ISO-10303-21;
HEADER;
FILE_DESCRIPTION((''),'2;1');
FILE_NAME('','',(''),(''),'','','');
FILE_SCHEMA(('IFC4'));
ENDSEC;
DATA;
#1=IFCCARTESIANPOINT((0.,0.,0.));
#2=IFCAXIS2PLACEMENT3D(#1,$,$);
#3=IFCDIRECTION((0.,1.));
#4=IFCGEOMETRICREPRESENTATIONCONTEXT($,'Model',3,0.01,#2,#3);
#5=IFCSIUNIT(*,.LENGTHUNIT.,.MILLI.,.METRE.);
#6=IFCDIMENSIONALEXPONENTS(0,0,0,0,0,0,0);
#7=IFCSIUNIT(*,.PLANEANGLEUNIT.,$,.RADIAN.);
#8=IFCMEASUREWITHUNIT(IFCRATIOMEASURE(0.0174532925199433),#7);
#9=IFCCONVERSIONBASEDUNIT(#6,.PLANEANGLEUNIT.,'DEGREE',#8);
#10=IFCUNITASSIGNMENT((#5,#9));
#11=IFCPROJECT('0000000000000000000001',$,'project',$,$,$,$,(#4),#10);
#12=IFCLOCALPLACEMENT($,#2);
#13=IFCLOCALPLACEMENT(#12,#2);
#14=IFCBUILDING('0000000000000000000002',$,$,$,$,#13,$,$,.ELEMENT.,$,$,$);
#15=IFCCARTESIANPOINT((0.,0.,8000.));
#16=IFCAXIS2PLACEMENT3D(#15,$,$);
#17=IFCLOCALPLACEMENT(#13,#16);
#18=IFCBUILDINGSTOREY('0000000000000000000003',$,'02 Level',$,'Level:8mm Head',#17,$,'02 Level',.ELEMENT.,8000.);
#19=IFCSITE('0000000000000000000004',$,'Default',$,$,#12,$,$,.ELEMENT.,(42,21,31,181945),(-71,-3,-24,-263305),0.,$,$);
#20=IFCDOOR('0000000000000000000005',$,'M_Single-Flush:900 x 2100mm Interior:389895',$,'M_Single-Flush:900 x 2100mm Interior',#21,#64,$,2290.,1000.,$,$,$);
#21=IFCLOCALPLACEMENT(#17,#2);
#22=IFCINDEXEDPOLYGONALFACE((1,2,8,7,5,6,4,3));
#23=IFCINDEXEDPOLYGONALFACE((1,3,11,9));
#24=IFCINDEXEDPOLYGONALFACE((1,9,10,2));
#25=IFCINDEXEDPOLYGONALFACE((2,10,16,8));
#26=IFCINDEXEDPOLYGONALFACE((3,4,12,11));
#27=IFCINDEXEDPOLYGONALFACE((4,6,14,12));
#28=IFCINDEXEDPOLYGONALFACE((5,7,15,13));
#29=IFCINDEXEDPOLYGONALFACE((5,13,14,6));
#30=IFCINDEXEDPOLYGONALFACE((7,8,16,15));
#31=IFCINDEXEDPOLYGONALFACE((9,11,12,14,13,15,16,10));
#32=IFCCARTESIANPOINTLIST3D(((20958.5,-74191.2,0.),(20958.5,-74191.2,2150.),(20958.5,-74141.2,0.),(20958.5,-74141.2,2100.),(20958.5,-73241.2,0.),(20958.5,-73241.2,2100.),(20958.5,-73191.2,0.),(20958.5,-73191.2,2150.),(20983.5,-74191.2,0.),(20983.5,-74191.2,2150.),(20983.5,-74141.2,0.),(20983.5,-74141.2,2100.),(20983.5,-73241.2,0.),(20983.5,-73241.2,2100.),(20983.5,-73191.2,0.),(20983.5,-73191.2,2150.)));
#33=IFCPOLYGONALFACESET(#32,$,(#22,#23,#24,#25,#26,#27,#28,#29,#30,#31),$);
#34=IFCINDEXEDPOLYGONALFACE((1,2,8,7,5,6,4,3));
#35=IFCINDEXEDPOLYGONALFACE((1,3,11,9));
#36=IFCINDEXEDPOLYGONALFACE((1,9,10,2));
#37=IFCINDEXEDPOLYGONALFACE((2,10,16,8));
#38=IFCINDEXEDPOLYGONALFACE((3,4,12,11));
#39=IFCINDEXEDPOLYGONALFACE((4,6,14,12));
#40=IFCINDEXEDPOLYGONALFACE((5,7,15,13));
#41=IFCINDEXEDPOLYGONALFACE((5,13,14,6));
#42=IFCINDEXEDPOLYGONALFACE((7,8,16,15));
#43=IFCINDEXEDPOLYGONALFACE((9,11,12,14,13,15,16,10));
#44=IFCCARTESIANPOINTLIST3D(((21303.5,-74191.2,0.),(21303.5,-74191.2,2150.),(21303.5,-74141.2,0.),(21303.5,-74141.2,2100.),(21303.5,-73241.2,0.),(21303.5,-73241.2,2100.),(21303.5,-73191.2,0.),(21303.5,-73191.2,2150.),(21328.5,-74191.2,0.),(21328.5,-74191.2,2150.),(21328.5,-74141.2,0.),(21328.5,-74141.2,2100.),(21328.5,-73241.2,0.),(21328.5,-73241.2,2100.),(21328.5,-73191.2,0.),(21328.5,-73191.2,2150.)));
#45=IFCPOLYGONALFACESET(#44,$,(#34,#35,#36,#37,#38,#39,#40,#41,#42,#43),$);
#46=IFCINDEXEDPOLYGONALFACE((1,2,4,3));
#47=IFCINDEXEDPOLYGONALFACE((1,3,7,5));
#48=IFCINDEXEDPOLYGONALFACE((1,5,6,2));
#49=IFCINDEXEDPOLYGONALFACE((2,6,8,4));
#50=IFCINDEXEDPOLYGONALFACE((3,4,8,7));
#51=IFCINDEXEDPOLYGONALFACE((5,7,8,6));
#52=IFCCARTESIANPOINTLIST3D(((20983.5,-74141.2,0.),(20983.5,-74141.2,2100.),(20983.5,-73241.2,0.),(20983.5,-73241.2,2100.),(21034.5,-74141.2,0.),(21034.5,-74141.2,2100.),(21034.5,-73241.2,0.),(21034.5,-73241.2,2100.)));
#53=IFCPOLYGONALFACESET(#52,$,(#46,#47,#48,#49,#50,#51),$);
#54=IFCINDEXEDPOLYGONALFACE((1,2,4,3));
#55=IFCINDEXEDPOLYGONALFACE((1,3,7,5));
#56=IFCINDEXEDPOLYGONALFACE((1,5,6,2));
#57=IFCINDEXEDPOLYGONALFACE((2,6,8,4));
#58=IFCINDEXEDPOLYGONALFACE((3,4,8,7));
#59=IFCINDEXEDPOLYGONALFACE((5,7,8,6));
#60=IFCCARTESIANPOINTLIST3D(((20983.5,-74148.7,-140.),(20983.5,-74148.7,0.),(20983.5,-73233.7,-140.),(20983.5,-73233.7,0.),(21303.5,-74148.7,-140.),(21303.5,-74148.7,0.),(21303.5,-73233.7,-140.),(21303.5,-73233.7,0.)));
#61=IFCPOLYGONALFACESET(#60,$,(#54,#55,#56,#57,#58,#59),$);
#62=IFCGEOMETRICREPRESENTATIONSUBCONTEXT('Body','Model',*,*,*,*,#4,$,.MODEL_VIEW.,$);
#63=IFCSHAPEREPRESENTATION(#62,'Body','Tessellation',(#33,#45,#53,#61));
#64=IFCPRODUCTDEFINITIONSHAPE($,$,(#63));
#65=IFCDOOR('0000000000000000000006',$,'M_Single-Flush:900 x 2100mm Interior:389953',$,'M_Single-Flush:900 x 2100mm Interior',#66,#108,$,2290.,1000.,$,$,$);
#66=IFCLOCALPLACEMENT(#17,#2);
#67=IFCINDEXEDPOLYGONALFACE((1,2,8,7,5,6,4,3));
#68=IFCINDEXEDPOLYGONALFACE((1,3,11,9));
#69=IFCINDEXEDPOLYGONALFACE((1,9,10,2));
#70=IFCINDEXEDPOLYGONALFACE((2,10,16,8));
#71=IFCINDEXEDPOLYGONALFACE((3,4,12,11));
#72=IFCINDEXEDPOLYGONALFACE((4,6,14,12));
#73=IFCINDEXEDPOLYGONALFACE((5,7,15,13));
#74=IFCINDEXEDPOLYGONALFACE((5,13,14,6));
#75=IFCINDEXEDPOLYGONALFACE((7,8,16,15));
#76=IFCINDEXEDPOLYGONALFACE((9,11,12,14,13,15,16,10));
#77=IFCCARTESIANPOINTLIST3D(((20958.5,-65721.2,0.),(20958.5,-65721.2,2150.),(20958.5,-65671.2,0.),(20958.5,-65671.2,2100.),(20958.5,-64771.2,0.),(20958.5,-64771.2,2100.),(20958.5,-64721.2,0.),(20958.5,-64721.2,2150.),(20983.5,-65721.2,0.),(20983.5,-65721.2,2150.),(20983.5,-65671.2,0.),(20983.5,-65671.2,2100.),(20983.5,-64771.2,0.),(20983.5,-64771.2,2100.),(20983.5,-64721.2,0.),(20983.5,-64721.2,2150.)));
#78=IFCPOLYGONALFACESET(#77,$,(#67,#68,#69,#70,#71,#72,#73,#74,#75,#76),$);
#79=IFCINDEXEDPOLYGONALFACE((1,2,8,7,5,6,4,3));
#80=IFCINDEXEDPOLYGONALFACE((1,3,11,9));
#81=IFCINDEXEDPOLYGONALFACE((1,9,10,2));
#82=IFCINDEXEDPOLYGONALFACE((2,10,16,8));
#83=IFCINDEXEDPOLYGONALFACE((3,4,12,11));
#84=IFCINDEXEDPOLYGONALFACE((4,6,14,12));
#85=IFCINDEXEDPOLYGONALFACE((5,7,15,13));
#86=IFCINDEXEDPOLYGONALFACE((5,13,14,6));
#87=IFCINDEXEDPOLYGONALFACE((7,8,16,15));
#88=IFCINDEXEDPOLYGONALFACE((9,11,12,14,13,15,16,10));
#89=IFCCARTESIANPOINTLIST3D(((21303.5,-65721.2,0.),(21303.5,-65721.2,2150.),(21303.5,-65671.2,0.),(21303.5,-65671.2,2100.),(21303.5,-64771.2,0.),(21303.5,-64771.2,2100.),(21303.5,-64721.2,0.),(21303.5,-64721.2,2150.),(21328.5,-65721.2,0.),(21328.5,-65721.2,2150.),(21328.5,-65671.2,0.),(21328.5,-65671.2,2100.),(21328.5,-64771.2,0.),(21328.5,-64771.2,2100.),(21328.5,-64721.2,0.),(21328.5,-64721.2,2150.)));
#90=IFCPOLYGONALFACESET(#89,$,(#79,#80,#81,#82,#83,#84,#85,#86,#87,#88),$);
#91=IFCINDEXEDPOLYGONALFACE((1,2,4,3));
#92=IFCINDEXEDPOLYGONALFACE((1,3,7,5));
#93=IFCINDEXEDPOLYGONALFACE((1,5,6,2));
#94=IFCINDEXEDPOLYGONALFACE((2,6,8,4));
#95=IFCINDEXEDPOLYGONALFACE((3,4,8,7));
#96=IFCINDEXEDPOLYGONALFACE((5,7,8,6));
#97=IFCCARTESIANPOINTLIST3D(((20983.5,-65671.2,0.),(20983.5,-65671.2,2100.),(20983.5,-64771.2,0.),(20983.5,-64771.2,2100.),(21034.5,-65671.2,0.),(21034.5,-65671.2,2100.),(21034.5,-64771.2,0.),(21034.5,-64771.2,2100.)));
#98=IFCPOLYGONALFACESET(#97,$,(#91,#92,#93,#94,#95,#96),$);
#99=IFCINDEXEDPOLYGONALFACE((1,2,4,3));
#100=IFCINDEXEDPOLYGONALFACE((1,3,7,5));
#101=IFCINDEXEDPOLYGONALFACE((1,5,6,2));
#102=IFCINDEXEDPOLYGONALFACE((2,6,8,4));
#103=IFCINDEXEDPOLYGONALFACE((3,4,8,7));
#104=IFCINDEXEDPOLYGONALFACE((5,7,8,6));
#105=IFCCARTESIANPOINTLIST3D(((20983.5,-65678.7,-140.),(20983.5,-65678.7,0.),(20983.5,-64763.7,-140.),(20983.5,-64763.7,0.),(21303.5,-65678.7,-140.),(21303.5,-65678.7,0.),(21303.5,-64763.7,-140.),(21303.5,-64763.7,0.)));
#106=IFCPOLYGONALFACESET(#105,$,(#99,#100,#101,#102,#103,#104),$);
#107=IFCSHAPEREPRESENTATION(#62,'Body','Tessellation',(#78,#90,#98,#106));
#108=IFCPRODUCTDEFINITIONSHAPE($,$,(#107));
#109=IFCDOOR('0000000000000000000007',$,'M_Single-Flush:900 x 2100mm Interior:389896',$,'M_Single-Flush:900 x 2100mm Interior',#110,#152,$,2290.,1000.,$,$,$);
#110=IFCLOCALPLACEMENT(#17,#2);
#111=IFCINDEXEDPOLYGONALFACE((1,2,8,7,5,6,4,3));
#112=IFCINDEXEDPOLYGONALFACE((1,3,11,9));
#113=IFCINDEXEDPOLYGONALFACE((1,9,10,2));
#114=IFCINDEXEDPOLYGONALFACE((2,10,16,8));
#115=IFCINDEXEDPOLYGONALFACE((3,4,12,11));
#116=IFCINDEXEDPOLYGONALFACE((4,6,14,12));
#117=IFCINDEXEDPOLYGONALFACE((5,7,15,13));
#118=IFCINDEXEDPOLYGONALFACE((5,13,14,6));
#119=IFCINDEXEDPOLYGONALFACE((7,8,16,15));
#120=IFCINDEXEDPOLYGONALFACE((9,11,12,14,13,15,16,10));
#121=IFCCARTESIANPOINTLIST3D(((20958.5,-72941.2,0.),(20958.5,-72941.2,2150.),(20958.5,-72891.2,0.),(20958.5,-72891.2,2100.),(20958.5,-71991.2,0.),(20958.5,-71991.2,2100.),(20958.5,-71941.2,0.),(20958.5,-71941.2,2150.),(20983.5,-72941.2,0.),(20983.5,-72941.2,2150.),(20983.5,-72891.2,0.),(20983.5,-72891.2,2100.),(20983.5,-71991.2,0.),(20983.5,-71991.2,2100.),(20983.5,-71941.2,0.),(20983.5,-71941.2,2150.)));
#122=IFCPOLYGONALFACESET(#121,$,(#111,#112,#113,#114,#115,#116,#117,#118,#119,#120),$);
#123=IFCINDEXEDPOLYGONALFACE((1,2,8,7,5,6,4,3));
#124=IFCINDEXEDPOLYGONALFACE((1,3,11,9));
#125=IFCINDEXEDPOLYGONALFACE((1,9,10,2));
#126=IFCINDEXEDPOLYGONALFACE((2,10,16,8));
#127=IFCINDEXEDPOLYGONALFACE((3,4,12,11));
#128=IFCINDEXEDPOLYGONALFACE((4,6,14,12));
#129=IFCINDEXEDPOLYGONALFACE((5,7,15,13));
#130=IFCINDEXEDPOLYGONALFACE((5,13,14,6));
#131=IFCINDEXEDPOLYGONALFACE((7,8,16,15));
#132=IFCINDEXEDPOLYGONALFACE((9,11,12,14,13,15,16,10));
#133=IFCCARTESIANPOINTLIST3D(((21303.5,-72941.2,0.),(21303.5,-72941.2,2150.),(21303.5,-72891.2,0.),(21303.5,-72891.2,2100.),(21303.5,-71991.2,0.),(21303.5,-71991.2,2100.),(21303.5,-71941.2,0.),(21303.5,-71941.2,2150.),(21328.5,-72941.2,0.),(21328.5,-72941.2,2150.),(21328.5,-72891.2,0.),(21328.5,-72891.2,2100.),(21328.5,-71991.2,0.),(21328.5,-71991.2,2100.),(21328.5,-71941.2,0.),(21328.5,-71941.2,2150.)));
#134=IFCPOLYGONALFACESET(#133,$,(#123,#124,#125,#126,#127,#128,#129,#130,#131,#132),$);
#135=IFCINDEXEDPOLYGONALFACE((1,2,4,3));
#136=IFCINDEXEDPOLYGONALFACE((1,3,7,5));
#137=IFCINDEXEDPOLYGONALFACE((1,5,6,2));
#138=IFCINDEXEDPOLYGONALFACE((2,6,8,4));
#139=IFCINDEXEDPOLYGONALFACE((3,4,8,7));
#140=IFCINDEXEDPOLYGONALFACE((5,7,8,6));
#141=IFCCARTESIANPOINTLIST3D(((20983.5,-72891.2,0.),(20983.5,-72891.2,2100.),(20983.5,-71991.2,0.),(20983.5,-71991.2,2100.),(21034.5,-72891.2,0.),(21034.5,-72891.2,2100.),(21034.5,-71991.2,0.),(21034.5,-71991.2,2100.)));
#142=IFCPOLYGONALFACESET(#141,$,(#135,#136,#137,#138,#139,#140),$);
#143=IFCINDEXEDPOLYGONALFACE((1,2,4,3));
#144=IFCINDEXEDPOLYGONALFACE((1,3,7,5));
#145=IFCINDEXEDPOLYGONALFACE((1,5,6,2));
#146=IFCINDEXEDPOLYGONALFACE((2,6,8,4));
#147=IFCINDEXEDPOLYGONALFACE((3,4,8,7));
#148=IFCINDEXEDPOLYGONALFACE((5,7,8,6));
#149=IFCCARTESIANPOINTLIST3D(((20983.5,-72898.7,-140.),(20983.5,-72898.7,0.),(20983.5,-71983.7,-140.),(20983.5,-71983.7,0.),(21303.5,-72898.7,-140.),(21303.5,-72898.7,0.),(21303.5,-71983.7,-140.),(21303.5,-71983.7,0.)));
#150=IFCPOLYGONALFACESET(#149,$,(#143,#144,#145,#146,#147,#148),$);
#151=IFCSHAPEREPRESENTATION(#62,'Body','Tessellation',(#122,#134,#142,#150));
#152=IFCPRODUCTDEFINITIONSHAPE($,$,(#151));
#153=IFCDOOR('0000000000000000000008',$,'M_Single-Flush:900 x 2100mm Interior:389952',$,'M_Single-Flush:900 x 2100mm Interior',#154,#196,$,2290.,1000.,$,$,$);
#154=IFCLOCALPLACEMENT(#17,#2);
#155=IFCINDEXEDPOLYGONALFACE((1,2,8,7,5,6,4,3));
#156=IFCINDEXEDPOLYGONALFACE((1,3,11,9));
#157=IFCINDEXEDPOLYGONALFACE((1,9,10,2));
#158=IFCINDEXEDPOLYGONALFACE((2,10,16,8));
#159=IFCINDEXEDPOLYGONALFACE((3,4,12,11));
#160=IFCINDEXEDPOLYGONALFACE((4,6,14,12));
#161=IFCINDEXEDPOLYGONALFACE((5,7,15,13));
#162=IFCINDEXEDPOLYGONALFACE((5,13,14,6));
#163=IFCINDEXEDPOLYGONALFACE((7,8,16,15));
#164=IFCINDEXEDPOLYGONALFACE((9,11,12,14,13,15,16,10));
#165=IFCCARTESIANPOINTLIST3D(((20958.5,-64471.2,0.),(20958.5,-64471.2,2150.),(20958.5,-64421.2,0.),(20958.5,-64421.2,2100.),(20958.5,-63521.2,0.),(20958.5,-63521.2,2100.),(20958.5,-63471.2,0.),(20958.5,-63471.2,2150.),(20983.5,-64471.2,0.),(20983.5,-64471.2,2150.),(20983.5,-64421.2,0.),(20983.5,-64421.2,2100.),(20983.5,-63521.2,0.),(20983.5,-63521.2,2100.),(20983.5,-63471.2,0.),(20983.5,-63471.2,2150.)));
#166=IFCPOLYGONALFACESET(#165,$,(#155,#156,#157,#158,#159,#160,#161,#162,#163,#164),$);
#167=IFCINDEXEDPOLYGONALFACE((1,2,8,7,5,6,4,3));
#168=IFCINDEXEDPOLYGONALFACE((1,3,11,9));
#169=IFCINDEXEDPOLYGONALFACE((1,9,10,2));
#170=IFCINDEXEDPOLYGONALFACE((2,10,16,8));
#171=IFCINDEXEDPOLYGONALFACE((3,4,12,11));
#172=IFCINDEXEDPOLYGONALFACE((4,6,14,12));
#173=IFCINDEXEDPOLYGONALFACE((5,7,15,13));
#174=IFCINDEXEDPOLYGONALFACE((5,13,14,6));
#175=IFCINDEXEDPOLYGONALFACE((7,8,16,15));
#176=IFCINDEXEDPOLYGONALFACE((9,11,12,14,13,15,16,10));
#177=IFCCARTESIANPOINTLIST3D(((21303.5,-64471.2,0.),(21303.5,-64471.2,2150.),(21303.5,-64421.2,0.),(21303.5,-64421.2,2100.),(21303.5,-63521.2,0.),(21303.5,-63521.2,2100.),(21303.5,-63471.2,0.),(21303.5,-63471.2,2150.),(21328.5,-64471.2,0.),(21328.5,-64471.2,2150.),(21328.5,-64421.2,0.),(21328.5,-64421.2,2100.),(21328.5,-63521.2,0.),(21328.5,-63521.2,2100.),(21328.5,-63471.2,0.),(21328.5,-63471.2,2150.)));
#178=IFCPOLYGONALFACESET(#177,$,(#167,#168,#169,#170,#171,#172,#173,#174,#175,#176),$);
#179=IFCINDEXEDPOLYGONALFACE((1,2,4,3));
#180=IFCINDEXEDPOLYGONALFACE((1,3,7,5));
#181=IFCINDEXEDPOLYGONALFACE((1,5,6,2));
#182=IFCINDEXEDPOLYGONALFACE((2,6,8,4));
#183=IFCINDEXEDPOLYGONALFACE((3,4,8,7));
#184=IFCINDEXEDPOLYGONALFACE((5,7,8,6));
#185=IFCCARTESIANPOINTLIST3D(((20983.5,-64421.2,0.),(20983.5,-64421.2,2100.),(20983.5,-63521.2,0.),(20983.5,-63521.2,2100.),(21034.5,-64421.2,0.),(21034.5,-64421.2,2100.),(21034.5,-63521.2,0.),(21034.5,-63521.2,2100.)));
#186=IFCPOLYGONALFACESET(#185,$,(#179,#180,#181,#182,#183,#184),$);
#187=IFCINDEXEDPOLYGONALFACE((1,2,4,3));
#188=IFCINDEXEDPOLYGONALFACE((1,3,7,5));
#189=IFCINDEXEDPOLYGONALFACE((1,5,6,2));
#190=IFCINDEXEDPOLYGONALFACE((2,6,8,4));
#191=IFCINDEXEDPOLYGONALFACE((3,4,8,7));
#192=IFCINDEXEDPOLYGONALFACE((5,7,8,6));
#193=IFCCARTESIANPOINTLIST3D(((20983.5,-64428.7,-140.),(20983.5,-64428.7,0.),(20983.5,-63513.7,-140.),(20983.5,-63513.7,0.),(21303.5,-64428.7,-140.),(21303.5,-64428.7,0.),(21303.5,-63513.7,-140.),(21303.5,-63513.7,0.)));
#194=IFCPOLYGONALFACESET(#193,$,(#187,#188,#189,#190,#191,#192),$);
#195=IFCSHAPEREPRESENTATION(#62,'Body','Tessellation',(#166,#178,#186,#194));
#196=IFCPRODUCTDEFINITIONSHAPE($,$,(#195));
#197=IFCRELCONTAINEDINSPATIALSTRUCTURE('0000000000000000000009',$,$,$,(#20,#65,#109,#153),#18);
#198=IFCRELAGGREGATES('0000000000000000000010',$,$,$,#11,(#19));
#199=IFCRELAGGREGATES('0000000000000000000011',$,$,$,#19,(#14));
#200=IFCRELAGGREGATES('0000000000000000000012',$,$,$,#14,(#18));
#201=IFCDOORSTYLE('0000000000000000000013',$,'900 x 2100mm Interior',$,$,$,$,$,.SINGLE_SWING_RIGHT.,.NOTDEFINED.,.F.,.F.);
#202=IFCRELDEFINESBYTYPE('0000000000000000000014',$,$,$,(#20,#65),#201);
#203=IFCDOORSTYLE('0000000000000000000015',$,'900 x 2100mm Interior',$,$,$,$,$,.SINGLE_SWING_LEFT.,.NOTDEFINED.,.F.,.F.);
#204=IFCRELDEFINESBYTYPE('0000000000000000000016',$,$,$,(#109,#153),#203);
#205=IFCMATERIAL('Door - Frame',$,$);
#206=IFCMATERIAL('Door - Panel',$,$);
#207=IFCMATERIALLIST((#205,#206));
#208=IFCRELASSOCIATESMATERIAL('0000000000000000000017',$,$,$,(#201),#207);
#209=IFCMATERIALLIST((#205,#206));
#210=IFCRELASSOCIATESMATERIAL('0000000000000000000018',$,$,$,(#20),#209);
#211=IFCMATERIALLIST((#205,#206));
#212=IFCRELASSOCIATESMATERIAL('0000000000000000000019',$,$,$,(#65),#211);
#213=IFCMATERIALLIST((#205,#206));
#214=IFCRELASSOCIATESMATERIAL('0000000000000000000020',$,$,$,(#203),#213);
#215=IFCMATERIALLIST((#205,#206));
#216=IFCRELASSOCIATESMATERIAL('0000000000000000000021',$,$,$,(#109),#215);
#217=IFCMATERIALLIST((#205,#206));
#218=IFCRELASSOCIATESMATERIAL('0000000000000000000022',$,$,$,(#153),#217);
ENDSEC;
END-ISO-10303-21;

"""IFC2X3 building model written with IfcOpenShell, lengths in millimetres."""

from ifc_helpers import new_model, entity, si_unit, converted_unit, direction, frame, frame_2d, origin, origin_2d_with_axis, place, context, subcontext, project, spatial, polyline, rectangle, outline, extrude, source, transform, mapped, material, material_list, type_object, type_shapes, element, save


model = new_model("IFC2X3")

# Units and contexts
model_context = context("Model", 3, precision=0.01, world=origin(), true_north=direction((0.0, 1.0)))
body_context = subcontext(model_context, "Body", "Model", "MODEL_VIEW")
ifc_project = project(units=[si_unit("LENGTHUNIT", "METRE", prefix="MILLI"), converted_unit("PLANEANGLEUNIT", "DEGREE", entity("IfcRatioMeasure", 0.0174532925199433), si_unit("PLANEANGLEUNIT", "RADIAN"), dimensions=[0, 0, 0, 0, 0, 0, 0])], contexts=[model_context])

# Site, building, storey
site_placement = place(None, origin())
site = spatial("IfcSite", under=ifc_project, at=site_placement, Name="Default", CompositionType="ELEMENT", RefLatitude=(42, 21, 31, 181945), RefLongitude=(-71, -3, -24, -263305), RefElevation=0.0)
building_placement = place(site_placement, origin())
building = spatial("IfcBuilding", under=site, at=building_placement, CompositionType="ELEMENT")
storey_placement = place(building_placement, frame((0.0, 0.0, 8000.0)))
storey = spatial("IfcBuildingStorey", under=building, at=storey_placement, Name="02 Level", ObjectType="Level:8mm Head", LongName="02 Level", CompositionType="ELEMENT", Elevation=8000.0)

# Doors
ifc_material_1 = material(Name="Door - Frame")
ifc_material_2 = material(Name="Door - Panel")
ifc_material_list_1 = material_list([ifc_material_1, ifc_material_2])
ifc_material_list_2 = material_list([ifc_material_1, ifc_material_2])
door_style_1 = type_object("IfcDoorStyle", Name="900 x 2100mm Interior", ConstructionType="NOTDEFINED", OperationType="SINGLE_SWING_RIGHT", ParameterTakesPrecedence=False, Sizeable=False, material=ifc_material_list_2)
shared_shape_1 = source(origin(), body_context, "Body", "SweptSolid", [
    extrude(outline(polyline([(-500.0, -1087.5), (500.0, -1087.5), (500.0, 1062.5), (450.0, 1062.5), (450.0, -1037.5), (-450.0, -1037.5), (-450.0, 1062.5), (-500.0, 1062.5), (-500.0, -1087.5)])), frame((450.0, 320.0, 1202.5), z_axis=(0.0, 1.0, 0.0), x_axis=(1.0, 0.0, 0.0)), (0.0, 0.0, 1.0), 25.0),
    extrude(outline(polyline([(-1087.5, -500.0), (1062.5, -500.0), (1062.5, -450.0), (-1037.5, -450.0), (-1037.5, 450.0), (1062.5, 450.0), (1062.5, 500.0), (-1087.5, 500.0), (-1087.5, -500.0)])), frame((450.0, -25.0, 1202.5), z_axis=(0.0, 1.0, 0.0), x_axis=(0.0, 0.0, -1.0)), (0.0, 0.0, 1.0), 25.0),
    extrude(rectangle(XDim=51.0, YDim=900.0, at=frame_2d((0.0, 0.0), x_axis=(1.0, 0.0))), frame((450.0, 294.5, 140.0), z_axis=(0.0, 0.0, 1.0), x_axis=(0.0, 1.0, 0.0)), (0.0, 0.0, 1.0), 2100.0),
    extrude(rectangle(XDim=915.0, YDim=320.0, at=origin_2d_with_axis()), frame((450.0, 160.0, 0.0), z_axis=(0.0, 0.0, 1.0), x_axis=(-1.0, 0.0, 0.0)), (0.0, 0.0, 1.0), 140.0),
])
type_shapes(door_style_1, [shared_shape_1])
door_1_placement = place(storey_placement, frame((21303.5, -74141.2, -140.0), z_axis=(0.0, 0.0, 1.0), x_axis=(0.0, 1.0, 0.0)))
element("IfcDoor", 1, at=door_1_placement, inside=storey, type_object=door_style_1, material=ifc_material_list_1, Name="M_Single-Flush:900 x 2100mm Interior:389895", ObjectType="M_Single-Flush:900 x 2100mm Interior", OverallHeight=2290.0, OverallWidth=1000.0, context=body_context, shape_type="MappedRepresentation", body=[
    mapped(shared_shape_1, transform((0.0, 0.0, 0.0), scale=1.0)),
])
ifc_material_list_3 = material_list([ifc_material_1, ifc_material_2])
door_2_placement = place(storey_placement, frame((21303.5, -65671.2, -140.0), z_axis=(0.0, 0.0, 1.0), x_axis=(0.0, 1.0, 0.0)))
element("IfcDoor", 2, at=door_2_placement, inside=storey, type_object=door_style_1, material=ifc_material_list_3, Name="M_Single-Flush:900 x 2100mm Interior:389953", ObjectType="M_Single-Flush:900 x 2100mm Interior", OverallHeight=2290.0, OverallWidth=1000.0, context=body_context, shape_type="MappedRepresentation", body=[
    mapped(shared_shape_1, transform((0.0, 0.0, 0.0), scale=1.0)),
])
ifc_material_list_4 = material_list([ifc_material_1, ifc_material_2])
ifc_material_list_5 = material_list([ifc_material_1, ifc_material_2])
door_style_2 = type_object("IfcDoorStyle", Name="900 x 2100mm Interior", ConstructionType="NOTDEFINED", OperationType="SINGLE_SWING_LEFT", ParameterTakesPrecedence=False, Sizeable=False, material=ifc_material_list_5)
shared_shape_2 = source(origin(), body_context, "Body", "SweptSolid", [
    extrude(outline(polyline([(-500.0, -1087.5), (500.0, -1087.5), (500.0, 1062.5), (450.0, 1062.5), (450.0, -1037.5), (-450.0, -1037.5), (-450.0, 1062.5), (-500.0, 1062.5), (-500.0, -1087.5)])), frame((450.0, 345.0, 1202.5), z_axis=(0.0, -1.0, 0.0), x_axis=(-1.0, 0.0, 0.0)), (0.0, 0.0, 1.0), 25.0),
    extrude(outline(polyline([(-1087.5, -500.0), (1062.5, -500.0), (1062.5, -450.0), (-1037.5, -450.0), (-1037.5, 450.0), (1062.5, 450.0), (1062.5, 500.0), (-1087.5, 500.0), (-1087.5, -500.0)])), frame((450.0, 0.0, 1202.5), z_axis=(0.0, -1.0, 0.0), x_axis=(0.0, 0.0, -1.0)), (0.0, 0.0, 1.0), 25.0),
    extrude(rectangle(XDim=900.0, YDim=51.0, at=origin_2d_with_axis()), frame((450.0, 294.5, 140.0)), (0.0, 0.0, 1.0), 2100.0),
    extrude(rectangle(XDim=320.0, YDim=915.0, at=origin_2d_with_axis()), frame((450.0, 160.0, 0.0), z_axis=(0.0, 0.0, 1.0), x_axis=(0.0, -1.0, 0.0)), (0.0, 0.0, 1.0), 140.0),
])
type_shapes(door_style_2, [shared_shape_2])
door_3_placement = place(storey_placement, frame((21303.5, -72891.2, -140.0), z_axis=(0.0, 0.0, 1.0), x_axis=(0.0, 1.0, 0.0)))
element("IfcDoor", 3, at=door_3_placement, inside=storey, type_object=door_style_2, material=ifc_material_list_4, Name="M_Single-Flush:900 x 2100mm Interior:389896", ObjectType="M_Single-Flush:900 x 2100mm Interior", OverallHeight=2290.0, OverallWidth=1000.0, context=body_context, shape_type="MappedRepresentation", body=[
    mapped(shared_shape_2, transform((0.0, 0.0, 0.0), scale=1.0)),
])
ifc_material_list_6 = material_list([ifc_material_1, ifc_material_2])
door_4_placement = place(storey_placement, frame((21303.5, -64421.2, -140.0), z_axis=(0.0, 0.0, 1.0), x_axis=(0.0, 1.0, 0.0)))
element("IfcDoor", 4, at=door_4_placement, inside=storey, type_object=door_style_2, material=ifc_material_list_6, Name="M_Single-Flush:900 x 2100mm Interior:389952", ObjectType="M_Single-Flush:900 x 2100mm Interior", OverallHeight=2290.0, OverallWidth=1000.0, context=body_context, shape_type="MappedRepresentation", body=[
    mapped(shared_shape_2, transform((0.0, 0.0, 0.0), scale=1.0)),
])

save(model, "model.ifc")
